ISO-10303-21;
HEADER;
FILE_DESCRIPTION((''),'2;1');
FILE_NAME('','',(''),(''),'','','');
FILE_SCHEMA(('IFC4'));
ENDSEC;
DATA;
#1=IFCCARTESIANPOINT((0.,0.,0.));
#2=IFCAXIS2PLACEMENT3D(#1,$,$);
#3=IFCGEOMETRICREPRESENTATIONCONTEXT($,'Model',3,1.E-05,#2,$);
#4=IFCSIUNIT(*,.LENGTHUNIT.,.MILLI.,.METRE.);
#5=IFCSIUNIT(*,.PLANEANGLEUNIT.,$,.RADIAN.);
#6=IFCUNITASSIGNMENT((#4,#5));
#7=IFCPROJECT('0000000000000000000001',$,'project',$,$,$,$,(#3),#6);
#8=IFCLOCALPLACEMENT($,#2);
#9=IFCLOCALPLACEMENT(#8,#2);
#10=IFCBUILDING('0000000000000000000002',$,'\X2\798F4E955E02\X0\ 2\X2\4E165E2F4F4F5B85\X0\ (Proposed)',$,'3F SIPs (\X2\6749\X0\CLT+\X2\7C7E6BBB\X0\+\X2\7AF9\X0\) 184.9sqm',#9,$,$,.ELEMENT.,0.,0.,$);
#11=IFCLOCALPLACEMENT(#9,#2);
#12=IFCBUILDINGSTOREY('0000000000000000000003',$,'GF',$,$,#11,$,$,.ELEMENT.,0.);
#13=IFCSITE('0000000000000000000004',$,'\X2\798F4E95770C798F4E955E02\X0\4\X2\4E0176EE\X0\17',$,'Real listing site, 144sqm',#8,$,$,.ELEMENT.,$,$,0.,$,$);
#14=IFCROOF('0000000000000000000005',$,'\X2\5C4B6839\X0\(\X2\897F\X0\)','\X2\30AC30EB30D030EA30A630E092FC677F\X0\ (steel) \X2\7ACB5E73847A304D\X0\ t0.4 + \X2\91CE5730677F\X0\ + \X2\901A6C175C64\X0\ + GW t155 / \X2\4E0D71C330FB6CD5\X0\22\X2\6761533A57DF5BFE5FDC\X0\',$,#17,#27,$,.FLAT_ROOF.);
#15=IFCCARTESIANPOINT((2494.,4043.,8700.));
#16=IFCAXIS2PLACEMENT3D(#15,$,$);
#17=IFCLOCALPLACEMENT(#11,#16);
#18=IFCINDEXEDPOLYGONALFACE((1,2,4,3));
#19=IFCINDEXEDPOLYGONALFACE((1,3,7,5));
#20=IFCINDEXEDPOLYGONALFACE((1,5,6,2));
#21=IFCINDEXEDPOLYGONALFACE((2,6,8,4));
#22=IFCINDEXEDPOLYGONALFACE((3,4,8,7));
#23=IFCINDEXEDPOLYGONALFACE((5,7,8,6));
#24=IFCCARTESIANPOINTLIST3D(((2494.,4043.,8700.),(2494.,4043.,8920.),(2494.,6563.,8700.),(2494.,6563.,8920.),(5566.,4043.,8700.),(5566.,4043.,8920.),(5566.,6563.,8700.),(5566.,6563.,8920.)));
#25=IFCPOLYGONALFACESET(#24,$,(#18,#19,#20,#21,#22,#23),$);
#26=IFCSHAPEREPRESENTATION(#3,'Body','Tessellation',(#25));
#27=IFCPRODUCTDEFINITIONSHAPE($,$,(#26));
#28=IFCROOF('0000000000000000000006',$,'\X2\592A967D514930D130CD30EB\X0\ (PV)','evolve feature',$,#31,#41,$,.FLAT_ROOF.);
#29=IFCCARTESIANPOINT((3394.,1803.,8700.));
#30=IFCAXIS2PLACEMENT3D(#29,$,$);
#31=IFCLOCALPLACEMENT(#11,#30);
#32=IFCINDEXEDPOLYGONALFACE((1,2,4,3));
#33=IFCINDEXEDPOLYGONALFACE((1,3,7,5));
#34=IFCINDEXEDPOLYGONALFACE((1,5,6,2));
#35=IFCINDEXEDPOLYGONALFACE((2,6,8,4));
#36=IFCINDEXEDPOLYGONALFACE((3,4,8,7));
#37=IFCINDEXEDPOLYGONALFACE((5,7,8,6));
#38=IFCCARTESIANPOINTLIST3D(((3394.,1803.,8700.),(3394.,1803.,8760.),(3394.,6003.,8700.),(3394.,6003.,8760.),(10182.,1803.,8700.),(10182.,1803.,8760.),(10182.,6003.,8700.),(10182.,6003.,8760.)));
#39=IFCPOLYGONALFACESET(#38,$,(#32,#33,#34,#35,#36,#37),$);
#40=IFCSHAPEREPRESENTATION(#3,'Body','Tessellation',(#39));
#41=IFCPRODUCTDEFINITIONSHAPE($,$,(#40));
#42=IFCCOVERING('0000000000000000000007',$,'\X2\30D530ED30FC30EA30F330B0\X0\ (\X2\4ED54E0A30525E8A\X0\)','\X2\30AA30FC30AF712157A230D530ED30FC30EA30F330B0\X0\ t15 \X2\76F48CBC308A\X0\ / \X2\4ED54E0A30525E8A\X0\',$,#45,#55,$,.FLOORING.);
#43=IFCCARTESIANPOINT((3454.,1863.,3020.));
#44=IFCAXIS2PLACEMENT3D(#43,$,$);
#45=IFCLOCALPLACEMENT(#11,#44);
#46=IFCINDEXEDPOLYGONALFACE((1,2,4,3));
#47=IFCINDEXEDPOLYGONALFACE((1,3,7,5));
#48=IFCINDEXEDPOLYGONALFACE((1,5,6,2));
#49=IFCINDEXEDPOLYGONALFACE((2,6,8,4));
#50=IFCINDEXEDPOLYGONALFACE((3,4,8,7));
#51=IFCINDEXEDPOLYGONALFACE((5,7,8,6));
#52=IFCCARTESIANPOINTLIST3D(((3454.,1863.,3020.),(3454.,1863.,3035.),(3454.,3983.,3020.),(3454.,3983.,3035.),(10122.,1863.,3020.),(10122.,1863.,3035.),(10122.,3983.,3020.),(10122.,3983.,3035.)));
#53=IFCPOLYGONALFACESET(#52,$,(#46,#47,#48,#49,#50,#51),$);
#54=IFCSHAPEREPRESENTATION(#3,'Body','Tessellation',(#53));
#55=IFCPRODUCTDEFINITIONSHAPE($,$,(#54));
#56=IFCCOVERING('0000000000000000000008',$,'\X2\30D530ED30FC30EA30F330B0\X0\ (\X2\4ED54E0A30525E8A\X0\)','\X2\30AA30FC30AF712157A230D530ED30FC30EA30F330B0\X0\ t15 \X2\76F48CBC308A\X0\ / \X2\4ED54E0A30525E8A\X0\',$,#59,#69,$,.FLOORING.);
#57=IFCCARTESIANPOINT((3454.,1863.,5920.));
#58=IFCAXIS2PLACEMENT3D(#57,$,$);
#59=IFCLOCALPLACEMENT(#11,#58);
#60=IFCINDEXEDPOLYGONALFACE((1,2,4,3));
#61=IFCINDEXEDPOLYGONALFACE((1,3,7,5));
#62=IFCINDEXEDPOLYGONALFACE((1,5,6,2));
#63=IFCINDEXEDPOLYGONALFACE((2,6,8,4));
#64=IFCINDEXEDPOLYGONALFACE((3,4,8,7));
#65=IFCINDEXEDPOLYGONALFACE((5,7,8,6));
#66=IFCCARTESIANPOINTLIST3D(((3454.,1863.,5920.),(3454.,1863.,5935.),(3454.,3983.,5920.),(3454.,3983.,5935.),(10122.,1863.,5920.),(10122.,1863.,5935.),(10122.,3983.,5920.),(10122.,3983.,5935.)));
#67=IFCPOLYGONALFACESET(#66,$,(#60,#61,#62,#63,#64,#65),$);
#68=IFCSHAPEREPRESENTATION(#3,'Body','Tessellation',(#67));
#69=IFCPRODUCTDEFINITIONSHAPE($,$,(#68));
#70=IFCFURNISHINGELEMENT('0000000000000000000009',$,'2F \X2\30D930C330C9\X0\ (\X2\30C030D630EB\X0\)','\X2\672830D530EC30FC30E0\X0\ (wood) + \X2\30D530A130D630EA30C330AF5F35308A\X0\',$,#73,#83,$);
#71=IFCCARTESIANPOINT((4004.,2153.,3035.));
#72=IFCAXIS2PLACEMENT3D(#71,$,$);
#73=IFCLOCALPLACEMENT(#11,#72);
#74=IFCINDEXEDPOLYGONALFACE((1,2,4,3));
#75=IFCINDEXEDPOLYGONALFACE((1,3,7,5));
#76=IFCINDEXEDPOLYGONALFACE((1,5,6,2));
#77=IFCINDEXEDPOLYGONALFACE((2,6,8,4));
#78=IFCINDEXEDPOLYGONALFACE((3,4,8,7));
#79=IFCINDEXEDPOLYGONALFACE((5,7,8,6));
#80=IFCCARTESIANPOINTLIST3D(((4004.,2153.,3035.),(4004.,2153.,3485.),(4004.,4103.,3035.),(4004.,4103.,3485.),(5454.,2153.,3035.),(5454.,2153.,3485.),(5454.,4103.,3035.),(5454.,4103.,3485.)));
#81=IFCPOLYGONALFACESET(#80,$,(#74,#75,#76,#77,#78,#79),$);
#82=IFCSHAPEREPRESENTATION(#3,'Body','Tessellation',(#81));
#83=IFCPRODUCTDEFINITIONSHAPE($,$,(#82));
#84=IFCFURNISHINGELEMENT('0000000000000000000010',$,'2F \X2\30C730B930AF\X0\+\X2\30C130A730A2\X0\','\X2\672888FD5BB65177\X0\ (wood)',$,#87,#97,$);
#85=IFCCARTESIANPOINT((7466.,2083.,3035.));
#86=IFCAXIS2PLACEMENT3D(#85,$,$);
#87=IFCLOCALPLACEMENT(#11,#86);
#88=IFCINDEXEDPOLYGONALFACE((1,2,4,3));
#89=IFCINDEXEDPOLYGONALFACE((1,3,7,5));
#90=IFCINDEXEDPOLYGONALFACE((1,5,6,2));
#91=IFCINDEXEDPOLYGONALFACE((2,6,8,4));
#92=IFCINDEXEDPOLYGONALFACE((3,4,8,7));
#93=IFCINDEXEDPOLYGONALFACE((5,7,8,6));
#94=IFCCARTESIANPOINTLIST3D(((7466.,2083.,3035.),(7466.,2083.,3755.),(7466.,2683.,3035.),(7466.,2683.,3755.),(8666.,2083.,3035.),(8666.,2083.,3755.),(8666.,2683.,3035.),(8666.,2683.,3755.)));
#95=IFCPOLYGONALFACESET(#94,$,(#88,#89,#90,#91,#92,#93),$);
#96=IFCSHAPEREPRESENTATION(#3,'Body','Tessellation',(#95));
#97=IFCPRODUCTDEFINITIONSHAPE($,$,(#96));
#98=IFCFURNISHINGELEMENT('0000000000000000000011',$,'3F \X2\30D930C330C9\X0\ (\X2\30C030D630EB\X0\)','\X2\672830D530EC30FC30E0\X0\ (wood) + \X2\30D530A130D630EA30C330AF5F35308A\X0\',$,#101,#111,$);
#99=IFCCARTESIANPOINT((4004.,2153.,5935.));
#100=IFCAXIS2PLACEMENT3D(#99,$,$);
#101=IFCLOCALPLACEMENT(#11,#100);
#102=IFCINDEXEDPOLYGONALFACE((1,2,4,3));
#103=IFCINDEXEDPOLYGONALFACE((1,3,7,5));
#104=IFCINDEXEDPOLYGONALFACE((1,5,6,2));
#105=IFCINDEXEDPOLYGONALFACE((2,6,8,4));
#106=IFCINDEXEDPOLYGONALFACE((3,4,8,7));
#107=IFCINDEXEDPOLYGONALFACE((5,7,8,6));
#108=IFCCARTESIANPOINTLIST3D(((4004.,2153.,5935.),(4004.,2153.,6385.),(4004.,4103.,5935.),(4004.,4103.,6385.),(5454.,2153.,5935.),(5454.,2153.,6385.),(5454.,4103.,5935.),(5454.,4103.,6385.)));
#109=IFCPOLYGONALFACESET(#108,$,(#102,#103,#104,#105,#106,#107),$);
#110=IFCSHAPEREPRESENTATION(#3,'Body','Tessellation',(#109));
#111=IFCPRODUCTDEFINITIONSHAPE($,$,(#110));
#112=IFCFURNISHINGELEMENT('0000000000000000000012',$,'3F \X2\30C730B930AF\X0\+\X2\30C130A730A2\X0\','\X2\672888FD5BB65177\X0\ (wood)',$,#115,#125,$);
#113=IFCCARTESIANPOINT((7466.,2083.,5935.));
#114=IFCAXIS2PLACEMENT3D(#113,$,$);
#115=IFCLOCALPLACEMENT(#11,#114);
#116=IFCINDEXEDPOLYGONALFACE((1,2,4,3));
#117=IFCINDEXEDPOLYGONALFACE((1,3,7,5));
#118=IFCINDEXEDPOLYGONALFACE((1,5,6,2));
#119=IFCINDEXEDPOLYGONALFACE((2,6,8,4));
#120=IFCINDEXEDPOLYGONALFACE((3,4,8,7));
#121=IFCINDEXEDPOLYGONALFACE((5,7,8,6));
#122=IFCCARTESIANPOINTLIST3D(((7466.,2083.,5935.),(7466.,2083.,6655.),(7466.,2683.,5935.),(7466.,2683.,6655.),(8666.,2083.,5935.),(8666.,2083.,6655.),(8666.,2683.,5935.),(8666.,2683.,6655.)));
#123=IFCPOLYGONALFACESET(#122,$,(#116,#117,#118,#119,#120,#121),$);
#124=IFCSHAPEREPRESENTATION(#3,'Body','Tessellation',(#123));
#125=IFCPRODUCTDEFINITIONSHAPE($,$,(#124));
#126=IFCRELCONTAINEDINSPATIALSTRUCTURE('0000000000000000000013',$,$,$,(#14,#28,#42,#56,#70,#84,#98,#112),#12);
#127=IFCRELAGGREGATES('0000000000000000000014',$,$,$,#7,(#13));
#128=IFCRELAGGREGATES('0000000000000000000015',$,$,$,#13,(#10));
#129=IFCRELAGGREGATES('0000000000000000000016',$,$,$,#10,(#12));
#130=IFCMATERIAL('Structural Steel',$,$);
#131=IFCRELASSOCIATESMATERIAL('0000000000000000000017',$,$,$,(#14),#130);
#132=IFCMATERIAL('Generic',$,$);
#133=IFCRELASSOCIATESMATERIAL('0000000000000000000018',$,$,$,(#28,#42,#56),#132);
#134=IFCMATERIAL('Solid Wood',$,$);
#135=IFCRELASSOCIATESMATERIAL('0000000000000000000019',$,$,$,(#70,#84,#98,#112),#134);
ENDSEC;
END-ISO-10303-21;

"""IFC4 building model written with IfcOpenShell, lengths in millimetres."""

from ifc_helpers import new_model, si_unit, frame, frame_2d, origin, place, context, project, spatial, rectangle, extrude, material, element, save


model = new_model("IFC4")

# Units and contexts
model_context = context("Model", 3, precision=1e-05, world=origin())
ifc_project = project(units=[si_unit("LENGTHUNIT", "METRE", prefix="MILLI"), si_unit("PLANEANGLEUNIT", "RADIAN")], contexts=[model_context])

# Site, building, storey
site_placement = place(None, origin())
site = spatial("IfcSite", under=ifc_project, at=site_placement, Name="福井県福井市4丁目17", ObjectType="Real listing site, 144sqm", CompositionType="ELEMENT", RefElevation=0.0)
building_placement = place(site_placement, origin())
building = spatial("IfcBuilding", under=site, at=building_placement, Name="福井市 2世帯住宅 (Proposed)", ObjectType="3F SIPs (杉CLT+籾殻+竹) 184.9sqm", CompositionType="ELEMENT", ElevationOfRefHeight=0.0, ElevationOfTerrain=0.0)
storey_placement = place(building_placement, origin())
storey = spatial("IfcBuildingStorey", under=building, at=storey_placement, Name="GF", CompositionType="ELEMENT", Elevation=0.0)

# Shared definitions
ifc_material_1 = material(Name="Solid Wood")

# Roofs
ifc_material_2 = material(Name="Structural Steel")
roof_1_placement = place(storey_placement, frame((2494.0, 4043.0, 8700.0)))
element("IfcRoof", 1, at=roof_1_placement, inside=storey, material=ifc_material_2, Name="屋根(西)", Description="ガルバリウム鋼板 (steel) 立平葺き t0.4 + 野地板 + 通気層 + GW t155 / 不燃・法22条区域対応", PredefinedType="FLAT_ROOF", context=model_context, shape_type="SweptSolid", body=[
    extrude(rectangle(XDim=3072.0, YDim=2520.0, at=frame_2d((1536.0, 1260.0))), frame((2494.0, 4043.0, 8700.0)), (0.0, 0.0, 1.0), 220.0),
])
ifc_material_3 = material(Name="Generic")
roof_2_placement = place(storey_placement, frame((3394.0, 1803.0, 8700.0)))
element("IfcRoof", 2, at=roof_2_placement, inside=storey, material=ifc_material_3, Name="太陽光パネル (PV)", Description="evolve feature", PredefinedType="FLAT_ROOF", context=model_context, shape_type="SweptSolid", body=[
    extrude(rectangle(XDim=6788.0, YDim=4200.0, at=frame_2d((3394.0, 2100.0))), frame((3394.0, 1803.0, 8700.0)), (0.0, 0.0, 1.0), 60.0),
])

# Coverings
covering_1_placement = place(storey_placement, frame((3454.0, 1863.0, 3020.0)))
element("IfcCovering", 3, at=covering_1_placement, inside=storey, material=ifc_material_3, Name="フローリング (仕上げ床)", Description="オーク無垢フローリング t15 直貼り / 仕上げ床", PredefinedType="FLOORING", context=model_context, shape_type="SweptSolid", body=[
    extrude(rectangle(XDim=6668.0, YDim=2120.0, at=frame_2d((3334.0, 1060.0))), frame((3454.0, 1863.0, 3020.0)), (0.0, 0.0, 1.0), 15.0),
])
covering_2_placement = place(storey_placement, frame((3454.0, 1863.0, 5920.0)))
element("IfcCovering", 4, at=covering_2_placement, inside=storey, material=ifc_material_3, Name="フローリング (仕上げ床)", Description="オーク無垢フローリング t15 直貼り / 仕上げ床", PredefinedType="FLOORING", context=model_context, shape_type="SweptSolid", body=[
    extrude(rectangle(XDim=6668.0, YDim=2120.0, at=frame_2d((3334.0, 1060.0))), frame((3454.0, 1863.0, 5920.0)), (0.0, 0.0, 1.0), 15.0),
])

# Furnishing elements
furnishing_1_placement = place(storey_placement, frame((4004.0, 2153.0, 3035.0)))
element("IfcFurnishingElement", 5, at=furnishing_1_placement, inside=storey, material=ifc_material_1, Name="2F ベッド (ダブル)", Description="木フレーム (wood) + ファブリック張り", context=model_context, shape_type="SweptSolid", body=[
    extrude(rectangle(XDim=1450.0, YDim=1950.0, at=frame_2d((725.0, 975.0))), frame((4004.0, 2153.0, 3035.0)), (0.0, 0.0, 1.0), 450.0),
])
furnishing_2_placement = place(storey_placement, frame((7466.0, 2083.0, 3035.0)))
element("IfcFurnishingElement", 6, at=furnishing_2_placement, inside=storey, material=ifc_material_1, Name="2F デスク+チェア", Description="木製家具 (wood)", context=model_context, shape_type="SweptSolid", body=[
    extrude(rectangle(XDim=1200.0, YDim=600.0, at=frame_2d((600.0, 300.0))), frame((7466.0, 2083.0, 3035.0)), (0.0, 0.0, 1.0), 720.0),
])
furnishing_3_placement = place(storey_placement, frame((4004.0, 2153.0, 5935.0)))
element("IfcFurnishingElement", 7, at=furnishing_3_placement, inside=storey, material=ifc_material_1, Name="3F ベッド (ダブル)", Description="木フレーム (wood) + ファブリック張り", context=model_context, shape_type="SweptSolid", body=[
    extrude(rectangle(XDim=1450.0, YDim=1950.0, at=frame_2d((725.0, 975.0))), frame((4004.0, 2153.0, 5935.0)), (0.0, 0.0, 1.0), 450.0),
])
furnishing_4_placement = place(storey_placement, frame((7466.0, 2083.0, 5935.0)))
element("IfcFurnishingElement", 8, at=furnishing_4_placement, inside=storey, material=ifc_material_1, Name="3F デスク+チェア", Description="木製家具 (wood)", context=model_context, shape_type="SweptSolid", body=[
    extrude(rectangle(XDim=1200.0, YDim=600.0, at=frame_2d((600.0, 300.0))), frame((7466.0, 2083.0, 5935.0)), (0.0, 0.0, 1.0), 720.0),
])

save(model, "model.ifc")
